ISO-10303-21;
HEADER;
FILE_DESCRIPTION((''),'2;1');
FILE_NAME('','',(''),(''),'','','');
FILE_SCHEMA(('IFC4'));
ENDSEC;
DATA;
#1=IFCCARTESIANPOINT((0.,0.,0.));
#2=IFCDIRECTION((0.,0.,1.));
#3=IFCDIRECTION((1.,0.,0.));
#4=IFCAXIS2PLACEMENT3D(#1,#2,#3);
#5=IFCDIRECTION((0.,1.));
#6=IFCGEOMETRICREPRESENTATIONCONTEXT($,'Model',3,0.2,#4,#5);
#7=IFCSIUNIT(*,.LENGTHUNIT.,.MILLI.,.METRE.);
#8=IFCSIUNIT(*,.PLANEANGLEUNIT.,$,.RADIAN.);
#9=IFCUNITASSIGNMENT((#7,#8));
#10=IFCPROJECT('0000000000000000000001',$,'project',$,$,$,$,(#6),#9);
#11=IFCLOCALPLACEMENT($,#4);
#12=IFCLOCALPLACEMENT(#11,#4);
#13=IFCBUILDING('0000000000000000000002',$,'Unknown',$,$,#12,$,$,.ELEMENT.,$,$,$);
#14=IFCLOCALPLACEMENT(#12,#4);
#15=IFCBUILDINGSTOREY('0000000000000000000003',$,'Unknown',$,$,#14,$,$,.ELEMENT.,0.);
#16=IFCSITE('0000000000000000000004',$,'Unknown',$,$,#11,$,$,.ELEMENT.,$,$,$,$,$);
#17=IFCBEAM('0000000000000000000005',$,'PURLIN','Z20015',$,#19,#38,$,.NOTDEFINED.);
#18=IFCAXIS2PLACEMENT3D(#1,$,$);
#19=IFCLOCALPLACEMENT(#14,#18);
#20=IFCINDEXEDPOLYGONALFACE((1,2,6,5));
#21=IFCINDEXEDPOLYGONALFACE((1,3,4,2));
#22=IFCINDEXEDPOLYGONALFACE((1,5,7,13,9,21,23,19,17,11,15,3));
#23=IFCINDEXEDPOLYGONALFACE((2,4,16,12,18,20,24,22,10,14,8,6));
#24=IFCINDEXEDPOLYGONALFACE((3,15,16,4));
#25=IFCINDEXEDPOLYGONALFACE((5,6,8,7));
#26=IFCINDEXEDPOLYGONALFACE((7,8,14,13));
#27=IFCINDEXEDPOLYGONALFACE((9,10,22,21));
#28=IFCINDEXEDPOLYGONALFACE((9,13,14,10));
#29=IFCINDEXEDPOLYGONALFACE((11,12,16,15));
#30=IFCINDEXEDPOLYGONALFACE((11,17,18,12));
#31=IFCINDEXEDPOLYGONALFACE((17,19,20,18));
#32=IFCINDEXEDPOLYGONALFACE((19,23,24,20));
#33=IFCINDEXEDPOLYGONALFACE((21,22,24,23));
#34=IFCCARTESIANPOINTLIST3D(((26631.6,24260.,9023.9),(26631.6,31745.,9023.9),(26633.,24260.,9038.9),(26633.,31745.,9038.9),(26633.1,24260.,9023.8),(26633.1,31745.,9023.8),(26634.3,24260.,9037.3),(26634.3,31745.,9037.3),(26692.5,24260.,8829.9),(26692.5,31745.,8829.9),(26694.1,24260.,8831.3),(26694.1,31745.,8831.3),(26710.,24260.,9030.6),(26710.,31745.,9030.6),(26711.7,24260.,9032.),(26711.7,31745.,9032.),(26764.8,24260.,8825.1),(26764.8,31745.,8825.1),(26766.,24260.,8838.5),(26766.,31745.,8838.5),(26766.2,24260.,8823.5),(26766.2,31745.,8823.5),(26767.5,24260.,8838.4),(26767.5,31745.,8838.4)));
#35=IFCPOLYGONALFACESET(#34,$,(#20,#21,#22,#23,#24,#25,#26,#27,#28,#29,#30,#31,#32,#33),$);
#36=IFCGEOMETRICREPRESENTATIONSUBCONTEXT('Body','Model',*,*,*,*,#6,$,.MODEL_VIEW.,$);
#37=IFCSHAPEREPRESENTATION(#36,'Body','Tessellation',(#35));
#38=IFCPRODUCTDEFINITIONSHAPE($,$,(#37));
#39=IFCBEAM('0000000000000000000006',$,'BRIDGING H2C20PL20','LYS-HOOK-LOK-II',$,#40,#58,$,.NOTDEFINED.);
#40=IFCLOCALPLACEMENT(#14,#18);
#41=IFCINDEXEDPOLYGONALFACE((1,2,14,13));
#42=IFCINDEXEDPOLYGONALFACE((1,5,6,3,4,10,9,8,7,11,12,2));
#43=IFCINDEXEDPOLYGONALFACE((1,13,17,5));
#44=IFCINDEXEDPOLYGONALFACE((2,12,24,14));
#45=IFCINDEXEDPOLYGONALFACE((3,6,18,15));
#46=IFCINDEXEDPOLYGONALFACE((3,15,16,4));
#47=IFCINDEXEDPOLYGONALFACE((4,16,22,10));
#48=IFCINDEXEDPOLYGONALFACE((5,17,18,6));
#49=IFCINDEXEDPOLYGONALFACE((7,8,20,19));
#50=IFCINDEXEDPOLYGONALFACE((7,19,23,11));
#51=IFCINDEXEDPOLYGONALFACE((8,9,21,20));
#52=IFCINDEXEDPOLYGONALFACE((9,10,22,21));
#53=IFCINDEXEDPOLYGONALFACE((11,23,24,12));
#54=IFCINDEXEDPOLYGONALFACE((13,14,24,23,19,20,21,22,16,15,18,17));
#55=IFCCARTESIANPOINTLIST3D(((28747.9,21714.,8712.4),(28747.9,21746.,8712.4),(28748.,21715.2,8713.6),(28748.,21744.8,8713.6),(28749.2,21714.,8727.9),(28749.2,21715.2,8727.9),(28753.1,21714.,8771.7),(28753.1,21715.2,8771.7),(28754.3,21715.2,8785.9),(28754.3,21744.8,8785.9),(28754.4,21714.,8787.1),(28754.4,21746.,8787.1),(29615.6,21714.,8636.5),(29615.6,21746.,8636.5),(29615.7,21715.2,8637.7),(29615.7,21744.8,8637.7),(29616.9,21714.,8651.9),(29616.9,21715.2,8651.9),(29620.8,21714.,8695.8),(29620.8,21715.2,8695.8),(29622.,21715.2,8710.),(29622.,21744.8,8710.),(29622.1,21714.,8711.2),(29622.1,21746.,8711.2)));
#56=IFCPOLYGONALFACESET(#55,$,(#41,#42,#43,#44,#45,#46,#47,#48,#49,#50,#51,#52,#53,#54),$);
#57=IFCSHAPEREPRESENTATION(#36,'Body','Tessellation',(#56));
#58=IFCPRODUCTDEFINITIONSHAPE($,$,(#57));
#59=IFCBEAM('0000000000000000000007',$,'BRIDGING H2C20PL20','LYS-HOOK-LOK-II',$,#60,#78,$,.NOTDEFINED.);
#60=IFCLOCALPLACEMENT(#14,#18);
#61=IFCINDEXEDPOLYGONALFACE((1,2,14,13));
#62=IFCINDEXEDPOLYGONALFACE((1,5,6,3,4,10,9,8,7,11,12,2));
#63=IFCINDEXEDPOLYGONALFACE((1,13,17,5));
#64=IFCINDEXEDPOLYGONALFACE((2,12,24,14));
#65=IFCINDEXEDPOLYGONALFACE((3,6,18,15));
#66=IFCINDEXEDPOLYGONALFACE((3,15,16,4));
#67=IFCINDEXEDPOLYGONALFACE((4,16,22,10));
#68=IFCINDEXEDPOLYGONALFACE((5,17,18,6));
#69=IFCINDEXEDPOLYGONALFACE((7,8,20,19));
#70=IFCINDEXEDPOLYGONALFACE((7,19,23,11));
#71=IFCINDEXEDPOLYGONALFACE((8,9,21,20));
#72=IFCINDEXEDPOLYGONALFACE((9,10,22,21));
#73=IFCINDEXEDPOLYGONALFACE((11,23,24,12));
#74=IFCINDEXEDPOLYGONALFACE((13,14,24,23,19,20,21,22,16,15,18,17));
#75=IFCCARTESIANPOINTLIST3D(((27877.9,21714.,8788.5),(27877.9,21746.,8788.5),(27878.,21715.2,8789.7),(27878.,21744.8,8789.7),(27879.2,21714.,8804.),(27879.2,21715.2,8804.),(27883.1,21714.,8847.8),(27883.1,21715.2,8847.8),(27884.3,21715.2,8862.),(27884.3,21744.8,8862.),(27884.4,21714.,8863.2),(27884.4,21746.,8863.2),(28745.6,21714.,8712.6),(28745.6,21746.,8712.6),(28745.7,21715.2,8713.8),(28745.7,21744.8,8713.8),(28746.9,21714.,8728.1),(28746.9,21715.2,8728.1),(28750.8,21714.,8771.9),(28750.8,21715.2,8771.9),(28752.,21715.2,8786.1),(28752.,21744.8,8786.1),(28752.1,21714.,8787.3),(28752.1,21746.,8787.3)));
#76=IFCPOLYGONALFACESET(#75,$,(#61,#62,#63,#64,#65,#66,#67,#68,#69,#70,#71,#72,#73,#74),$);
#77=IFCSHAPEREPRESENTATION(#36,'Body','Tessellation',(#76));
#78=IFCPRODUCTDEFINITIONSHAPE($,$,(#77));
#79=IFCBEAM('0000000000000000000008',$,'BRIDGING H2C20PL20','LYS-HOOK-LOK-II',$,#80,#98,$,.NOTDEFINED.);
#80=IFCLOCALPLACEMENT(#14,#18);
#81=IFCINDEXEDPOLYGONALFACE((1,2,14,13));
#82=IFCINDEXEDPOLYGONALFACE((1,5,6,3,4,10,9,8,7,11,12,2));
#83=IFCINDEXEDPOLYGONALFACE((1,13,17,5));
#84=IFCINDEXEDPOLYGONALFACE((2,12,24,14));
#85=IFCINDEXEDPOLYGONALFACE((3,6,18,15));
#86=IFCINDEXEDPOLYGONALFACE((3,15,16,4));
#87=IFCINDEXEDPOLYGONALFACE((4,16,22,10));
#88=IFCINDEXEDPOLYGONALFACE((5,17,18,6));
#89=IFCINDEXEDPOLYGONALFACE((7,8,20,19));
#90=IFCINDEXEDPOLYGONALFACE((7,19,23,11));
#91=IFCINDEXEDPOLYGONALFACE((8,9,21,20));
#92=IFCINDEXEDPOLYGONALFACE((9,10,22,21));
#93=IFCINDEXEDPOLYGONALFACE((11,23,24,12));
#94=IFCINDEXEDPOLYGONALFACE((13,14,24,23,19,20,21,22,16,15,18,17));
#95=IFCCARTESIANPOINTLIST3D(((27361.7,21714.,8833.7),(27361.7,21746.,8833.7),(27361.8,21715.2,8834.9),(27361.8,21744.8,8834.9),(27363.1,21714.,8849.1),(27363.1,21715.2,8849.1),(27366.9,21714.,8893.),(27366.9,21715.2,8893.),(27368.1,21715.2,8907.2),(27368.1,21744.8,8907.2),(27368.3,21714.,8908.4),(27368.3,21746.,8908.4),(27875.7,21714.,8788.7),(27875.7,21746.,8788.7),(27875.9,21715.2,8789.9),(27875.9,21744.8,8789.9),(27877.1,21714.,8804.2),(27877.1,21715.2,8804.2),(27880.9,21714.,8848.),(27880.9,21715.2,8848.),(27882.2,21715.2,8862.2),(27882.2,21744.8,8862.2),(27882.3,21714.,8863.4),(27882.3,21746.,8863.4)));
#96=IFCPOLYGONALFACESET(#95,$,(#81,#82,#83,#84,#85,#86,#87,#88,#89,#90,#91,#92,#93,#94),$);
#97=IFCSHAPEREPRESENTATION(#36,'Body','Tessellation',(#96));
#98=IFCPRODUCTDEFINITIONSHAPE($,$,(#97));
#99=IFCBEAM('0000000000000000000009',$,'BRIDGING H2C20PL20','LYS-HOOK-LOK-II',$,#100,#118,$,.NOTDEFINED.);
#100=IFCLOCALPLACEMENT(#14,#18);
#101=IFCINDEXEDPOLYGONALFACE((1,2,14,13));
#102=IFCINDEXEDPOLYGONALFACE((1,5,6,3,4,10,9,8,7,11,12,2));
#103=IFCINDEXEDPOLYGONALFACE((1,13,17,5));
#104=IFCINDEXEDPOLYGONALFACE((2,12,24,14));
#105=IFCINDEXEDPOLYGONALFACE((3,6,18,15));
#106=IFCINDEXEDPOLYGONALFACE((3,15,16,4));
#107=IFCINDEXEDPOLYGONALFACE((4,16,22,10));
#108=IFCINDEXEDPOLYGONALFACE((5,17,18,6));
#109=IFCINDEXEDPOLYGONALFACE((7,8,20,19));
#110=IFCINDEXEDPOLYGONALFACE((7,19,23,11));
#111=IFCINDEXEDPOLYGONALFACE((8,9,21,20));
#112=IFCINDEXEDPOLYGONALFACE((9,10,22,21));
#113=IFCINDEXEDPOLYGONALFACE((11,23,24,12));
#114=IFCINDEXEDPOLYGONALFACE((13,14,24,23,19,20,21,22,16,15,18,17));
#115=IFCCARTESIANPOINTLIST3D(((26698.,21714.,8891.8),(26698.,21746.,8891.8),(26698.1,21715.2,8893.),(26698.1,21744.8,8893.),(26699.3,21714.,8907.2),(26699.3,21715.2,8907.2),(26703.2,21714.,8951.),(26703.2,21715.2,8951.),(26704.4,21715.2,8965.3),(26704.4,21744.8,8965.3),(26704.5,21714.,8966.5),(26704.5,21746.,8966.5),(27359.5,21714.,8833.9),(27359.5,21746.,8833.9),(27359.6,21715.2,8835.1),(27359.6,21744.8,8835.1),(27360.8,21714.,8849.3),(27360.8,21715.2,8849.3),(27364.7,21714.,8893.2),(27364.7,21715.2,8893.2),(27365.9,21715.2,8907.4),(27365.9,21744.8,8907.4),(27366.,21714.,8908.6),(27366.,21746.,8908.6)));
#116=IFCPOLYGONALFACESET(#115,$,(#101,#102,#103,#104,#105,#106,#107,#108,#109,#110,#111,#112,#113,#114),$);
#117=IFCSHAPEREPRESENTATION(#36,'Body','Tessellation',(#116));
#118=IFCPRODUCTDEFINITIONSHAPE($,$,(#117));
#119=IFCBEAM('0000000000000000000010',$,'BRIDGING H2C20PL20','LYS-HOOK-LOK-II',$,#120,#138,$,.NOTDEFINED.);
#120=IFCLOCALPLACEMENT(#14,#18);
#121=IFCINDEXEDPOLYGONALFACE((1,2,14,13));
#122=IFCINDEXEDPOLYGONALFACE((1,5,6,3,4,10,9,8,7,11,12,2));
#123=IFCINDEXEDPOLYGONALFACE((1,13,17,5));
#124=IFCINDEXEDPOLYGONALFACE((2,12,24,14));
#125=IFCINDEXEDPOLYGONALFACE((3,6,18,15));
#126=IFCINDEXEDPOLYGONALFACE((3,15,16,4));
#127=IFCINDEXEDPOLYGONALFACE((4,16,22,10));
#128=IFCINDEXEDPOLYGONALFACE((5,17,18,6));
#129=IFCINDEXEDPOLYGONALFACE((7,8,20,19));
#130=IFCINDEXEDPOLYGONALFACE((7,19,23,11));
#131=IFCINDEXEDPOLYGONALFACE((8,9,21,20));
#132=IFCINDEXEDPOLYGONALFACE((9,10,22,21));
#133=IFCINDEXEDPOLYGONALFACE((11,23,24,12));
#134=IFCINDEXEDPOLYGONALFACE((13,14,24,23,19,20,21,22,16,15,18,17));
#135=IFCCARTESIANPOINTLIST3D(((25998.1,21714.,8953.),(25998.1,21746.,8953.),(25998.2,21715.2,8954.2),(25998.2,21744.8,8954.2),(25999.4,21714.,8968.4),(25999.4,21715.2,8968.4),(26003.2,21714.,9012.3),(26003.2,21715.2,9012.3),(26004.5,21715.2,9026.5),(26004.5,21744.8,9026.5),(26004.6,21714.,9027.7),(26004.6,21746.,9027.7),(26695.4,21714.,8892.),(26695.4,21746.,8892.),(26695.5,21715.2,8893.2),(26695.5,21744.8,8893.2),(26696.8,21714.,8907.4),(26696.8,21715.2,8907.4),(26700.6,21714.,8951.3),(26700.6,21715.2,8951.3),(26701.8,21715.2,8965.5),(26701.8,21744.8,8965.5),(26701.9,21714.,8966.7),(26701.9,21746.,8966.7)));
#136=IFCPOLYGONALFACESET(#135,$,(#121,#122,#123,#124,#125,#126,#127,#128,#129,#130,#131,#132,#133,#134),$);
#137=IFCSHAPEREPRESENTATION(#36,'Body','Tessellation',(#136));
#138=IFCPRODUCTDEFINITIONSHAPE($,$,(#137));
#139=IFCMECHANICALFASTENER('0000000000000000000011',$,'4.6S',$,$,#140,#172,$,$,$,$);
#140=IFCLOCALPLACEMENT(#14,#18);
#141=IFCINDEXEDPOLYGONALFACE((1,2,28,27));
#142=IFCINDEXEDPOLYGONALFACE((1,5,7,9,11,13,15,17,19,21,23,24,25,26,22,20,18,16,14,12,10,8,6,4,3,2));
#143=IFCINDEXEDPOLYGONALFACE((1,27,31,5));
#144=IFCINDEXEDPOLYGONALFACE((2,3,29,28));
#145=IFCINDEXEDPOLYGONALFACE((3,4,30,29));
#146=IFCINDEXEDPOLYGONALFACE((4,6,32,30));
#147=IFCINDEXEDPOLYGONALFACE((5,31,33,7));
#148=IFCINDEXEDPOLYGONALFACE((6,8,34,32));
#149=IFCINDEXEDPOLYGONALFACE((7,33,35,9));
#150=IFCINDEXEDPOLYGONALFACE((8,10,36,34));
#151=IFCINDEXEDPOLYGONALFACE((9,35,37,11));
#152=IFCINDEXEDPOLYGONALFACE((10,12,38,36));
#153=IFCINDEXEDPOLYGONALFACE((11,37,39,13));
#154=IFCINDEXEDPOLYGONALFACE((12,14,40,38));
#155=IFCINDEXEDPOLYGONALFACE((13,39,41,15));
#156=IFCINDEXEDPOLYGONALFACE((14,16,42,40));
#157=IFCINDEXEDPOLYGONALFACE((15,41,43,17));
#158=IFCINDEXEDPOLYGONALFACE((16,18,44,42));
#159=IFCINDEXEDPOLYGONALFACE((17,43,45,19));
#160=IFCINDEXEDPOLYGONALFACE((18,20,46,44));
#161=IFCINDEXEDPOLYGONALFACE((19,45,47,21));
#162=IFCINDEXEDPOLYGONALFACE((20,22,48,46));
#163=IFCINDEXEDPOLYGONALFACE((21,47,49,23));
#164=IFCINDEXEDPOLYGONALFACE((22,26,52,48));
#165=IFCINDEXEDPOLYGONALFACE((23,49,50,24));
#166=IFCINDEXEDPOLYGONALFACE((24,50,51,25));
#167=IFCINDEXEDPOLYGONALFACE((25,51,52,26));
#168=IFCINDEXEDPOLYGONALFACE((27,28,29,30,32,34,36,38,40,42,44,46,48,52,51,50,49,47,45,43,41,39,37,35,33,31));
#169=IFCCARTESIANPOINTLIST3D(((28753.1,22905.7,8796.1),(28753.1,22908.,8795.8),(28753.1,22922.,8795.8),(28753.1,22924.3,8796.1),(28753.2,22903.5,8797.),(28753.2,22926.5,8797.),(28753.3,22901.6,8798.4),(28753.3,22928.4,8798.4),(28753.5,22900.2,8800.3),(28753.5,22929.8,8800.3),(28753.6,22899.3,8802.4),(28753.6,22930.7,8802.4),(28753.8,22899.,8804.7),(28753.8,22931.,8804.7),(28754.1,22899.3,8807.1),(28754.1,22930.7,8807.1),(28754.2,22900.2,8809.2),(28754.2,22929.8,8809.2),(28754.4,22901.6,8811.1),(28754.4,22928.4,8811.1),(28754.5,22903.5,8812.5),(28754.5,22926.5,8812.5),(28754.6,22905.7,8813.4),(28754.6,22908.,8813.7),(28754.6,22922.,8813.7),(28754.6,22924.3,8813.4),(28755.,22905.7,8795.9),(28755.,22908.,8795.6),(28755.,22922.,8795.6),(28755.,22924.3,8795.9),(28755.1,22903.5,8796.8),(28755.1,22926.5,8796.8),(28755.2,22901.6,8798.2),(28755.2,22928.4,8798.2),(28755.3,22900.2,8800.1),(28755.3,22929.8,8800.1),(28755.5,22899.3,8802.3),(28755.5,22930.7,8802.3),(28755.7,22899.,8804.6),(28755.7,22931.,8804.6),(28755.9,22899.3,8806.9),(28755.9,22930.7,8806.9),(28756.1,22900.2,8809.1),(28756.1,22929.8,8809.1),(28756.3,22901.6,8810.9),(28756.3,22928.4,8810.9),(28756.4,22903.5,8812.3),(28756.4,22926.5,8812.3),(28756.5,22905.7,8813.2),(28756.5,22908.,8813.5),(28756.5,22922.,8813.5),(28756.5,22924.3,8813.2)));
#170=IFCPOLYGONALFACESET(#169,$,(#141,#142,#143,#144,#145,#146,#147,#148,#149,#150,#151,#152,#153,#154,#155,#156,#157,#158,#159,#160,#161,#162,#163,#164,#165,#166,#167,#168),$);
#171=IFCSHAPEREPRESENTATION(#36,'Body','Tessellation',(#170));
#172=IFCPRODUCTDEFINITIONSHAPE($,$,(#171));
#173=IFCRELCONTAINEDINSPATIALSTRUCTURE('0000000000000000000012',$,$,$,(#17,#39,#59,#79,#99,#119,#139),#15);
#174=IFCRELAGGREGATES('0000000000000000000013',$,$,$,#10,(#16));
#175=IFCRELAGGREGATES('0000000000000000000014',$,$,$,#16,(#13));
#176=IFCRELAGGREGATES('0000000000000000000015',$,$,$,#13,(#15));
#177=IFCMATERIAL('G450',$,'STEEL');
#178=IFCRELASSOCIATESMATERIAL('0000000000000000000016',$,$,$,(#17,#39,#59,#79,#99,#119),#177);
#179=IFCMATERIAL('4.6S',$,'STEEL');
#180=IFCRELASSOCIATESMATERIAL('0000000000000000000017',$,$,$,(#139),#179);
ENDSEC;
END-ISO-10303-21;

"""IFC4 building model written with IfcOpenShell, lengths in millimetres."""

from ifc_helpers import new_model, si_unit, direction, frame, origin_with_axes, place, context, subcontext, project, spatial, line, arc, indexed_curve, outline, extrude, source, transform, mapped, material, element, save


model = new_model("IFC4")

# Units and contexts
model_context = context("Model", 3, precision=0.2, world=origin_with_axes(), true_north=direction((0.0, 1.0)))
body_context = subcontext(model_context, "Body", "Model", "MODEL_VIEW")
ifc_project = project(units=[si_unit("LENGTHUNIT", "METRE", prefix="MILLI"), si_unit("PLANEANGLEUNIT", "RADIAN")], contexts=[model_context])

# Site, building, storey
site_placement = place(None, origin_with_axes())
site = spatial("IfcSite", under=ifc_project, at=site_placement, Name="Unknown", CompositionType="ELEMENT")
building_placement = place(site_placement, origin_with_axes())
building = spatial("IfcBuilding", under=site, at=building_placement, Name="Unknown", CompositionType="ELEMENT")
storey_placement = place(building_placement, origin_with_axes())
storey = spatial("IfcBuildingStorey", under=building, at=storey_placement, Name="Unknown", CompositionType="ELEMENT", Elevation=0.0)

# Beams
ifc_material_1 = material(Name="G450", Category="STEEL")
for number, where, z_axis, x_axis, name in (
    (1, (26702.1, 24260.0, 8931.0), (0.996195, 0.0, -0.087156), (0.0, 1.0, 0.0), "PURLIN"),
):
    element("IfcBeam", number, at=place(storey_placement, frame(where, z_axis=z_axis, x_axis=x_axis)), inside=storey, material=ifc_material_1, Name=name, Description="Z20015", PredefinedType="NOTDEFINED", context=body_context, shape_type="SolidModel", body=[
        extrude(outline(indexed_curve([(73.2, -101.5), (73.2, -86.5), (71.8, -86.5), (71.8, -100.0), (0.8, -100.0), (0.8, 101.5), (-78.2, 101.5), (-78.2, 86.5), (-76.8, 86.5), (-76.8, 100.0), (-0.8, 100.0), (-0.8, -101.5)], segments=[line(1, 2, 3, 4, 5, 6, 7, 8, 9, 10, 11, 12, 1)])), frame((0.0, 0.0, 0.0), z_axis=(-1.0, 0.0, 0.0), x_axis=(0.0, 0.0, 1.0)), (0.0, 0.0, -1.0), 7485.0),
    ])
for number, where, z_axis, x_axis, name in (
    (2, (28751.2, 21730.0, 8749.8), (0.0, -1.0, 0.0), (0.996195, 0.0, -0.087156), "BRIDGING H2C20PL20"),
    (3, (27881.2, 21730.0, 8825.9), (0.0, -1.0, 0.0), (0.996195, 0.0, -0.087148), "BRIDGING H2C20PL20"),
):
    element("IfcBeam", number, at=place(storey_placement, frame(where, z_axis=z_axis, x_axis=x_axis)), inside=storey, material=ifc_material_1, Name=name, Description="LYS-HOOK-LOK-II", PredefinedType="NOTDEFINED", context=body_context, shape_type="SolidModel", body=[
        extrude(outline(indexed_curve([(16.0, -37.5), (16.0, -22.0), (14.8, -22.0), (14.8, -36.3), (-14.8, -36.3), (-14.8, 36.3), (14.8, 36.3), (14.8, 22.0), (16.0, 22.0), (16.0, 37.5), (-16.0, 37.5), (-16.0, -37.5)], segments=[line(1, 2, 3, 4, 5, 6, 7, 8, 9, 10, 11, 12, 1)])), frame((0.0, 0.0, 0.0), z_axis=(-1.0, 0.0, 0.0), x_axis=(0.0, 0.0, 1.0)), (0.0, 0.0, -1.0), 871.0),
    ])
beam_1_placement = place(storey_placement, frame((27365.0, 21730.0, 8871.0), z_axis=(0.0, -1.0, 0.0), x_axis=(0.996194, 0.0, -0.087165)))
element("IfcBeam", 4, at=beam_1_placement, inside=storey, material=ifc_material_1, Name="BRIDGING H2C20PL20", Description="LYS-HOOK-LOK-II", PredefinedType="NOTDEFINED", context=body_context, shape_type="SolidModel", body=[
    extrude(outline(indexed_curve([(16.0, -37.5), (16.0, -22.0), (14.8, -22.0), (14.8, -36.3), (-14.8, -36.3), (-14.8, 36.3), (14.8, 36.3), (14.8, 22.0), (16.0, 22.0), (16.0, 37.5), (-16.0, 37.5), (-16.0, -37.5)], segments=[line(1, 2, 3, 4, 5, 6, 7, 8, 9, 10, 11, 12, 1)])), frame((0.0, 0.0, 0.0), z_axis=(-1.0, 0.0, 0.0), x_axis=(0.0, 0.0, 1.0)), (0.0, 0.0, -1.0), 516.0),
])
beam_2_placement = place(storey_placement, frame((26701.3, 21730.0, 8929.1), z_axis=(0.0, -1.0, 0.0), x_axis=(0.996194, 0.0, -0.08716)))
element("IfcBeam", 5, at=beam_2_placement, inside=storey, material=ifc_material_1, Name="BRIDGING H2C20PL20", Description="LYS-HOOK-LOK-II", PredefinedType="NOTDEFINED", context=body_context, shape_type="SolidModel", body=[
    extrude(outline(indexed_curve([(16.0, -37.5), (16.0, -22.0), (14.8, -22.0), (14.8, -36.3), (-14.8, -36.3), (-14.8, 36.3), (14.8, 36.3), (14.8, 22.0), (16.0, 22.0), (16.0, 37.5), (-16.0, 37.5), (-16.0, -37.5)], segments=[line(1, 2, 3, 4, 5, 6, 7, 8, 9, 10, 11, 12, 1)])), frame((0.0, 0.0, 0.0), z_axis=(-1.0, 0.0, 0.0), x_axis=(0.0, 0.0, 1.0)), (0.0, 0.0, -1.0), 664.0),
])
beam_3_placement = place(storey_placement, frame((26001.3, 21730.0, 8990.4), z_axis=(0.0, -1.0, 0.0), x_axis=(0.996195, 0.0, -0.087156)))
element("IfcBeam", 6, at=beam_3_placement, inside=storey, material=ifc_material_1, Name="BRIDGING H2C20PL20", Description="LYS-HOOK-LOK-II", PredefinedType="NOTDEFINED", context=body_context, shape_type="SolidModel", body=[
    extrude(outline(indexed_curve([(16.0, -37.5), (16.0, -22.0), (14.8, -22.0), (14.8, -36.3), (-14.8, -36.3), (-14.8, 36.3), (14.8, 36.3), (14.8, 22.0), (16.0, 22.0), (16.0, 37.5), (-16.0, 37.5), (-16.0, -37.5)], segments=[line(1, 2, 3, 4, 5, 6, 7, 8, 9, 10, 11, 12, 1)])), frame((0.0, 0.0, 0.0), z_axis=(-1.0, 0.0, 0.0), x_axis=(0.0, 0.0, 1.0)), (0.0, 0.0, -1.0), 700.0),
])

# Mechanical fastener
ifc_material_2 = material(Name="4.6S", Category="STEEL")
shared_shape_1 = source(origin_with_axes(), body_context, "Body", "SweptSolid", [
    extrude(outline(indexed_curve([(-7.0, 9.0), (7.0, 9.0), (7.0, 9.0), (13.4, 6.4), (16.0, 0.0), (13.4, -6.4), (7.0, -9.0), (-7.0, -9.0), (-7.8, -9.0), (-16.0, 0.0), (-13.4, 6.4)], segments=[line(1, 2, 3), arc(3, 4, 5), arc(5, 6, 7), line(7, 8), arc(8, 9, 10), arc(10, 11, 1)])), frame((0.0, 0.0, 0.9), z_axis=(0.0, 0.0, -1.0), x_axis=(0.0, 1.0, 0.0)), (0.0, 0.0, 1.0), 1.9),
])
for number, where, z_axis, x_axis, name in (
    (7, (28754.8, 22915.0, 8804.7), (-0.996195, 0.0, 0.087156), (0.087156, 0.0, 0.996195), "4.6S"),
):
    element("IfcMechanicalFastener", number, at=place(storey_placement, frame(where, z_axis=z_axis, x_axis=x_axis)), inside=storey, material=ifc_material_2, Name=name, context=body_context, shape_type="MappedRepresentation", body=[
        mapped(shared_shape_1, transform((0.0, 0.0, 0.0))),
    ])

save(model, "model.ifc")
